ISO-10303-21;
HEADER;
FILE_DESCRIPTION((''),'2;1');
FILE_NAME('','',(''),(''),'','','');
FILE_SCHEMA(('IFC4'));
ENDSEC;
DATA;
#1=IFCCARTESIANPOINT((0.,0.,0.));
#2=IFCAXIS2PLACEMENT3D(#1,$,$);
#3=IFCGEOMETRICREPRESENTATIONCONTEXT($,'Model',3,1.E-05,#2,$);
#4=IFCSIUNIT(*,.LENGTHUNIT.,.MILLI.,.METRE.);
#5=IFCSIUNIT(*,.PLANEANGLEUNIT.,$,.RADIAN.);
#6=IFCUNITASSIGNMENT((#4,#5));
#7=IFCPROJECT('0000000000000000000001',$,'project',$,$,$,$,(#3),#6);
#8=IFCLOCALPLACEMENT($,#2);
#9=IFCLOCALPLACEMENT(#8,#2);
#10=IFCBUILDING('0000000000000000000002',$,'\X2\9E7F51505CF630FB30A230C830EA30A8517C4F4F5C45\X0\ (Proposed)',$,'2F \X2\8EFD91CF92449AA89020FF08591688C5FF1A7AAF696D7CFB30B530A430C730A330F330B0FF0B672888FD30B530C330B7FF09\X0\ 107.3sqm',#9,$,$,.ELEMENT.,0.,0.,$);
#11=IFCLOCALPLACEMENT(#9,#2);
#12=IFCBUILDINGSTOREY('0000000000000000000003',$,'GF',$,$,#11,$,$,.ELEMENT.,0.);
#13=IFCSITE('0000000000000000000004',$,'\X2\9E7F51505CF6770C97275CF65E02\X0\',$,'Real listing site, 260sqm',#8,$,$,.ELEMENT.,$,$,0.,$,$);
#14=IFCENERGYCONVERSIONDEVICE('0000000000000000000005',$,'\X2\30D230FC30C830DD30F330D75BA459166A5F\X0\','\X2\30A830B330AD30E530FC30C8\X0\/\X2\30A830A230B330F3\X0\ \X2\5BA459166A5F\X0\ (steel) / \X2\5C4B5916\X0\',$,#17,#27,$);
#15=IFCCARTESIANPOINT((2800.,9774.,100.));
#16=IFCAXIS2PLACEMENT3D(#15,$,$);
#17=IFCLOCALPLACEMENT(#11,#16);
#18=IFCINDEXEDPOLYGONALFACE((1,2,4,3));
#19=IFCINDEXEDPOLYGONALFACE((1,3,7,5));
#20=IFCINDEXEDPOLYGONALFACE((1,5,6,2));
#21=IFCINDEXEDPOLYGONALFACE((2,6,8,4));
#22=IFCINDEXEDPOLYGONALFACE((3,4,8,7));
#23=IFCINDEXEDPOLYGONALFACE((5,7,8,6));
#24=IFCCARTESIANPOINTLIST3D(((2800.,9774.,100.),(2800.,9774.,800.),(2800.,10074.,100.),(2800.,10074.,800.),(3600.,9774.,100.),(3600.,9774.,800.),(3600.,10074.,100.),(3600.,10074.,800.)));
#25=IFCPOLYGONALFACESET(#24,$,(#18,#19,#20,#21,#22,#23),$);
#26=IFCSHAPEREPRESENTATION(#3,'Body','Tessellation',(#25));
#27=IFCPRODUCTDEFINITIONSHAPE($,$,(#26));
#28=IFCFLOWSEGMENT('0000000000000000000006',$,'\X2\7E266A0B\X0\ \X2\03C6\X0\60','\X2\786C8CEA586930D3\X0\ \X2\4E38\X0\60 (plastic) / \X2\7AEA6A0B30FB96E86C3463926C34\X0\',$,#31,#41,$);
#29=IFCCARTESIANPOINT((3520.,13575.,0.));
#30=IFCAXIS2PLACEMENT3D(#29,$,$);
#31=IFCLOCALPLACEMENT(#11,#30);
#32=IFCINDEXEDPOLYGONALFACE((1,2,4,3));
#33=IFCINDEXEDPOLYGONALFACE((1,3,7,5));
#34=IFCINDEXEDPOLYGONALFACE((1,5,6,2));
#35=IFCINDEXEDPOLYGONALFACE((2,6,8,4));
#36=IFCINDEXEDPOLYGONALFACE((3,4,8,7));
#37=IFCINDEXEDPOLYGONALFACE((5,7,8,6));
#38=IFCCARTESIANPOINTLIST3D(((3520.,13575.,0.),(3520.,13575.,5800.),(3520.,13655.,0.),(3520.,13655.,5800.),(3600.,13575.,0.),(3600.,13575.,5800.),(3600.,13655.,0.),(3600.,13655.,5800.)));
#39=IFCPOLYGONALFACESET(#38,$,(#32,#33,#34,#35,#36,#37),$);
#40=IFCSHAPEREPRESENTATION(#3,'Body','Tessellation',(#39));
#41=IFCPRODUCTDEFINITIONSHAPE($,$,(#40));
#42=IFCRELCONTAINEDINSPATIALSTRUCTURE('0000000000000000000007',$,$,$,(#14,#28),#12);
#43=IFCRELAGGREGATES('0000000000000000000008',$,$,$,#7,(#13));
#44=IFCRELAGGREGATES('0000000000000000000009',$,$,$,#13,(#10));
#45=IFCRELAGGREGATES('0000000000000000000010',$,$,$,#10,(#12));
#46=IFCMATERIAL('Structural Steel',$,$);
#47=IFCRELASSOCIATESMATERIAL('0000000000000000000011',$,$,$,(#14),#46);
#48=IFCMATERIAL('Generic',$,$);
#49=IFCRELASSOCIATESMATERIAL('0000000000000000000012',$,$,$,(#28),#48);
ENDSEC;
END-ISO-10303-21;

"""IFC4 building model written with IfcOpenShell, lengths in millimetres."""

from ifc_helpers import new_model, si_unit, frame, frame_2d, origin, place, context, project, spatial, rectangle, extrude, material, element, save


model = new_model("IFC4")

# Units and contexts
model_context = context("Model", 3, precision=1e-05, world=origin())
ifc_project = project(units=[si_unit("LENGTHUNIT", "METRE", prefix="MILLI"), si_unit("PLANEANGLEUNIT", "RADIAN")], contexts=[model_context])

# Site, building, storey
site_placement = place(None, origin())
site = spatial("IfcSite", under=ifc_project, at=site_placement, Name="鹿児島県霧島市", ObjectType="Real listing site, 260sqm", CompositionType="ELEMENT", RefElevation=0.0)
building_placement = place(site_placement, origin())
building = spatial("IfcBuilding", under=site, at=building_placement, Name="鹿児島・アトリエ兼住居 (Proposed)", ObjectType="2F 軽量鉄骨造（外装：窯業系サイディング＋木製サッシ） 107.3sqm", CompositionType="ELEMENT", ElevationOfRefHeight=0.0, ElevationOfTerrain=0.0)
storey_placement = place(building_placement, origin())
storey = spatial("IfcBuildingStorey", under=building, at=storey_placement, Name="GF", CompositionType="ELEMENT", Elevation=0.0)

# Shared definitions
ifc_material_1 = material(Name="Generic")

# Energy conversion device
ifc_material_2 = material(Name="Structural Steel")
energy_conversion_device_placement = place(storey_placement, frame((2800.0, 9774.0, 100.0)))
element("IfcEnergyConversionDevice", 1, at=energy_conversion_device_placement, inside=storey, material=ifc_material_2, Name="ヒートポンプ室外機", Description="エコキュート/エアコン 室外機 (steel) / 屋外", context=model_context, shape_type="SweptSolid", body=[
    extrude(rectangle(XDim=800.0, YDim=300.0, at=frame_2d((400.0, 150.0))), frame((2800.0, 9774.0, 100.0)), (0.0, 0.0, 1.0), 700.0),
])

# Flow segment
flow_segment_placement = place(storey_placement, frame((3520.0, 13575.0, 0.0)))
element("IfcFlowSegment", 2, at=flow_segment_placement, inside=storey, material=ifc_material_1, Name="縦樋 φ60", Description="硬質塩ビ 丸60 (plastic) / 竪樋・雨水排水", context=model_context, shape_type="SweptSolid", body=[
    extrude(rectangle(XDim=80.0, YDim=80.0, at=frame_2d((40.0, 40.0))), frame((3520.0, 13575.0, 0.0)), (0.0, 0.0, 1.0), 5800.0),
])

save(model, "model.ifc")
